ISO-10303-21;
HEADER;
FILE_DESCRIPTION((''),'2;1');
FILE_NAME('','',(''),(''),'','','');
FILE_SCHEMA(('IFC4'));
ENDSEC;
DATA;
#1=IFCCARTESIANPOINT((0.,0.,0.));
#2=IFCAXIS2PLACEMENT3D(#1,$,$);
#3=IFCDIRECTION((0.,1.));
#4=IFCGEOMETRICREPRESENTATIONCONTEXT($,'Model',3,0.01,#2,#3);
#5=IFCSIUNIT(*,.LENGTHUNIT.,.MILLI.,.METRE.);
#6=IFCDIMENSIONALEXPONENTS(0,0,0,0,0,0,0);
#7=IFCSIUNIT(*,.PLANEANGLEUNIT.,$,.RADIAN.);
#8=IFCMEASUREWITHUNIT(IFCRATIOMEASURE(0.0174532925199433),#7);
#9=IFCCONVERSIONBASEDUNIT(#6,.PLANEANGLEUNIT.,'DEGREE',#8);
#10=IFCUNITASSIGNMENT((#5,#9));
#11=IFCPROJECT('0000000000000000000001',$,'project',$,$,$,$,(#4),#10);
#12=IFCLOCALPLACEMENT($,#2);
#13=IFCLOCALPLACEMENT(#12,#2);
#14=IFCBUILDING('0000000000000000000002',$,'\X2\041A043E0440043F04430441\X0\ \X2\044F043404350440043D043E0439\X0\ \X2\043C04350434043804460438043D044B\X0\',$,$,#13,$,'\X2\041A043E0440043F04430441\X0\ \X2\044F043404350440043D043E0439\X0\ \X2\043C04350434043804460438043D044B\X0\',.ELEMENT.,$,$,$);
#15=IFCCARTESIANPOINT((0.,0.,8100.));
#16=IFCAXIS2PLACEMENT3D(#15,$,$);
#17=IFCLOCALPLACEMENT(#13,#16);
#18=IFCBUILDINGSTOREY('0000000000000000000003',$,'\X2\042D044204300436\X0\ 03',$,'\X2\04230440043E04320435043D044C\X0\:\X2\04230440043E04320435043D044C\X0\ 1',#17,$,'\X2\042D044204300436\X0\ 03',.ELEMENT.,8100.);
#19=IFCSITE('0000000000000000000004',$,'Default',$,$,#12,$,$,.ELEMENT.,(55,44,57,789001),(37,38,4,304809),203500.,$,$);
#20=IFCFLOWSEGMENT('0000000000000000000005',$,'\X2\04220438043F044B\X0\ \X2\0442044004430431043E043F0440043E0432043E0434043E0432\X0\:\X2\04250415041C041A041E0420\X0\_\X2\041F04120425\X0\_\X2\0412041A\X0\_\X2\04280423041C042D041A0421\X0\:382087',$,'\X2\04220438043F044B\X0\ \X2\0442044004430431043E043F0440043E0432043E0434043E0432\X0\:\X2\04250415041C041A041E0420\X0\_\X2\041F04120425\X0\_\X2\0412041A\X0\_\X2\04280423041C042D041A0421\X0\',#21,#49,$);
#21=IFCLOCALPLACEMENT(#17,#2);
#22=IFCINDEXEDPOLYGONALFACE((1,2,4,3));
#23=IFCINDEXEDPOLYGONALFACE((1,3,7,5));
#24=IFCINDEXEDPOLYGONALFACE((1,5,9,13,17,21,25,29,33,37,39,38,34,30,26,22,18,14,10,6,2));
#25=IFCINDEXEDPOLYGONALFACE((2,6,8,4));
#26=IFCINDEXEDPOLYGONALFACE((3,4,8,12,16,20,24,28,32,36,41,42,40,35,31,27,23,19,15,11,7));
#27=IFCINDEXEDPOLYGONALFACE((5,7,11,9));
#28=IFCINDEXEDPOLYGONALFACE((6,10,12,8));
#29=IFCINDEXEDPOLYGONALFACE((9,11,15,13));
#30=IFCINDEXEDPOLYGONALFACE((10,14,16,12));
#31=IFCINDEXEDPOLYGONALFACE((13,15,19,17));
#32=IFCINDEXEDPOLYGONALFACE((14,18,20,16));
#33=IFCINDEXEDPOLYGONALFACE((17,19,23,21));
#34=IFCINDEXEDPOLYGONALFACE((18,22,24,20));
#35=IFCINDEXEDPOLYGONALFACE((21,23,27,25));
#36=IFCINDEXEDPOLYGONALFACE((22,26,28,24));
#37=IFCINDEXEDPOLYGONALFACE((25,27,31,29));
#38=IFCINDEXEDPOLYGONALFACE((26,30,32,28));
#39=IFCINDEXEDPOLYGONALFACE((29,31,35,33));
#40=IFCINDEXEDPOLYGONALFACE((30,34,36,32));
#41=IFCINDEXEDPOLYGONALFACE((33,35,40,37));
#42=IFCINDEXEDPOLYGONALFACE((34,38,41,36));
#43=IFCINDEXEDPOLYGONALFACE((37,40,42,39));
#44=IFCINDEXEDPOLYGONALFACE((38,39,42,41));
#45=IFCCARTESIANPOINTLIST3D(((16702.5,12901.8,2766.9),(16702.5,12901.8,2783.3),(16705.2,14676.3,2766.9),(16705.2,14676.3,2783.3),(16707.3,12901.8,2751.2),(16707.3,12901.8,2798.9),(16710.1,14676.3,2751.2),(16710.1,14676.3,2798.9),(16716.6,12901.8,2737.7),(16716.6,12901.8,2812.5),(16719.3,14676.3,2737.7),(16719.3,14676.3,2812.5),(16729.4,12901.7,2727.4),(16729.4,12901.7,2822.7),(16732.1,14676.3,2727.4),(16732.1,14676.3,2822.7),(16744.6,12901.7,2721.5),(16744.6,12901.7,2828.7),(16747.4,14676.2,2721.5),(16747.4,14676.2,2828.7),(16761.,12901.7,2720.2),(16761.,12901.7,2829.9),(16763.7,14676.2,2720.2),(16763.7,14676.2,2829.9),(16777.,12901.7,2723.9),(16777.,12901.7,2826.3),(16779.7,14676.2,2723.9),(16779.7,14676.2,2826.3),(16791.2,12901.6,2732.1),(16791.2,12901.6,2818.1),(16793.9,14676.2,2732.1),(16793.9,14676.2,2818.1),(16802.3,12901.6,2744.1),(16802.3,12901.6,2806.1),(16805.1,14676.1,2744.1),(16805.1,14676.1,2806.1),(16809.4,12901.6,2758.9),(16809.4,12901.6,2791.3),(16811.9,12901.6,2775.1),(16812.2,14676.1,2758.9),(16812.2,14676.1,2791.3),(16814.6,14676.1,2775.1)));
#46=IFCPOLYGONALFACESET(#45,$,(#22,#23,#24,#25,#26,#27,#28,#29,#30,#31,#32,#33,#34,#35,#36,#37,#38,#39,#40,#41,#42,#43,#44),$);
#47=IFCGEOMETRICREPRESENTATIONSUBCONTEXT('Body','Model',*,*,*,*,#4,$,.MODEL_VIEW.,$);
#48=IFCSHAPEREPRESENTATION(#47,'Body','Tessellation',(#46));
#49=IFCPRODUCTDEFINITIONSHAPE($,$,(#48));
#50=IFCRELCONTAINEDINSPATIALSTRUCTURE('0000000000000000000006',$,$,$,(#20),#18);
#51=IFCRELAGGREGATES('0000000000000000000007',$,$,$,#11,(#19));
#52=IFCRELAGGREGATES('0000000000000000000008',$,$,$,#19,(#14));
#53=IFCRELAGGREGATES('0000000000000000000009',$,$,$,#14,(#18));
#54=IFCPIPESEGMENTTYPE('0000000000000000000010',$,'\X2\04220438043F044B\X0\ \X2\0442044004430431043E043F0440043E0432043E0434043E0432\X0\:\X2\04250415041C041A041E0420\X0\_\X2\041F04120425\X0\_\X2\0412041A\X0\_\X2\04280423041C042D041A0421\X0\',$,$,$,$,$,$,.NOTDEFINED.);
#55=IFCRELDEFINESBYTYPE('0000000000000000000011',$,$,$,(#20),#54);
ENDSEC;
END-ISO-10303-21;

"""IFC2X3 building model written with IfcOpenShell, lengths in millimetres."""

from ifc_helpers import new_model, entity, si_unit, converted_unit, direction, frame, origin, origin_2d_with_axis, place, context, subcontext, project, spatial, circle, extrude, type_object, element, save


model = new_model("IFC2X3")

# Units and contexts
model_context = context("Model", 3, precision=0.01, world=origin(), true_north=direction((0.0, 1.0)))
body_context = subcontext(model_context, "Body", "Model", "MODEL_VIEW")
ifc_project = project(units=[si_unit("LENGTHUNIT", "METRE", prefix="MILLI"), converted_unit("PLANEANGLEUNIT", "DEGREE", entity("IfcRatioMeasure", 0.0174532925199433), si_unit("PLANEANGLEUNIT", "RADIAN"), dimensions=[0, 0, 0, 0, 0, 0, 0])], contexts=[model_context])

# Site, building, storey
site_placement = place(None, frame((0.0, 0.0, 0.0)))
site = spatial("IfcSite", under=ifc_project, at=site_placement, Name="Default", CompositionType="ELEMENT", RefLatitude=(55, 44, 57, 789001), RefLongitude=(37, 38, 4, 304809), RefElevation=203500.0)
building_placement = place(site_placement, origin())
building = spatial("IfcBuilding", under=site, at=building_placement, Name="Корпус ядерной медицины", LongName="Корпус ядерной медицины", CompositionType="ELEMENT")
storey_placement = place(building_placement, frame((0.0, 0.0, 8100.0)))
storey = spatial("IfcBuildingStorey", under=building, at=storey_placement, Name="Этаж 03", ObjectType="Уровень:Уровень 1", LongName="Этаж 03", CompositionType="ELEMENT", Elevation=8100.0)

# Flow segment
pipe_segment_type = type_object("IfcPipeSegmentType", Name="Типы трубопроводов:ХЕМКОР_ПВХ_ВК_ШУМЭКС", PredefinedType="NOTDEFINED")
flow_segment_1_placement = place(storey_placement, frame((16700.3, 12901.6, 2718.5)))
element("IfcFlowSegment", 1, at=flow_segment_1_placement, inside=storey, type_object=pipe_segment_type, Name="Типы трубопроводов:ХЕМКОР_ПВХ_ВК_ШУМЭКС:382087", ObjectType="Типы трубопроводов:ХЕМКОР_ПВХ_ВК_ШУМЭКС", context=body_context, shape_type="SweptSolid", body=[
    extrude(circle(Radius=55.0, at=origin_2d_with_axis()), frame((56.6, 0.1, 56.6), z_axis=(0.001547, 0.999999, 0.0), x_axis=(0.999999, -0.001547, 0.0)), (0.0, 0.0, 1.0), 1774.5),
])

save(model, "model.ifc")
